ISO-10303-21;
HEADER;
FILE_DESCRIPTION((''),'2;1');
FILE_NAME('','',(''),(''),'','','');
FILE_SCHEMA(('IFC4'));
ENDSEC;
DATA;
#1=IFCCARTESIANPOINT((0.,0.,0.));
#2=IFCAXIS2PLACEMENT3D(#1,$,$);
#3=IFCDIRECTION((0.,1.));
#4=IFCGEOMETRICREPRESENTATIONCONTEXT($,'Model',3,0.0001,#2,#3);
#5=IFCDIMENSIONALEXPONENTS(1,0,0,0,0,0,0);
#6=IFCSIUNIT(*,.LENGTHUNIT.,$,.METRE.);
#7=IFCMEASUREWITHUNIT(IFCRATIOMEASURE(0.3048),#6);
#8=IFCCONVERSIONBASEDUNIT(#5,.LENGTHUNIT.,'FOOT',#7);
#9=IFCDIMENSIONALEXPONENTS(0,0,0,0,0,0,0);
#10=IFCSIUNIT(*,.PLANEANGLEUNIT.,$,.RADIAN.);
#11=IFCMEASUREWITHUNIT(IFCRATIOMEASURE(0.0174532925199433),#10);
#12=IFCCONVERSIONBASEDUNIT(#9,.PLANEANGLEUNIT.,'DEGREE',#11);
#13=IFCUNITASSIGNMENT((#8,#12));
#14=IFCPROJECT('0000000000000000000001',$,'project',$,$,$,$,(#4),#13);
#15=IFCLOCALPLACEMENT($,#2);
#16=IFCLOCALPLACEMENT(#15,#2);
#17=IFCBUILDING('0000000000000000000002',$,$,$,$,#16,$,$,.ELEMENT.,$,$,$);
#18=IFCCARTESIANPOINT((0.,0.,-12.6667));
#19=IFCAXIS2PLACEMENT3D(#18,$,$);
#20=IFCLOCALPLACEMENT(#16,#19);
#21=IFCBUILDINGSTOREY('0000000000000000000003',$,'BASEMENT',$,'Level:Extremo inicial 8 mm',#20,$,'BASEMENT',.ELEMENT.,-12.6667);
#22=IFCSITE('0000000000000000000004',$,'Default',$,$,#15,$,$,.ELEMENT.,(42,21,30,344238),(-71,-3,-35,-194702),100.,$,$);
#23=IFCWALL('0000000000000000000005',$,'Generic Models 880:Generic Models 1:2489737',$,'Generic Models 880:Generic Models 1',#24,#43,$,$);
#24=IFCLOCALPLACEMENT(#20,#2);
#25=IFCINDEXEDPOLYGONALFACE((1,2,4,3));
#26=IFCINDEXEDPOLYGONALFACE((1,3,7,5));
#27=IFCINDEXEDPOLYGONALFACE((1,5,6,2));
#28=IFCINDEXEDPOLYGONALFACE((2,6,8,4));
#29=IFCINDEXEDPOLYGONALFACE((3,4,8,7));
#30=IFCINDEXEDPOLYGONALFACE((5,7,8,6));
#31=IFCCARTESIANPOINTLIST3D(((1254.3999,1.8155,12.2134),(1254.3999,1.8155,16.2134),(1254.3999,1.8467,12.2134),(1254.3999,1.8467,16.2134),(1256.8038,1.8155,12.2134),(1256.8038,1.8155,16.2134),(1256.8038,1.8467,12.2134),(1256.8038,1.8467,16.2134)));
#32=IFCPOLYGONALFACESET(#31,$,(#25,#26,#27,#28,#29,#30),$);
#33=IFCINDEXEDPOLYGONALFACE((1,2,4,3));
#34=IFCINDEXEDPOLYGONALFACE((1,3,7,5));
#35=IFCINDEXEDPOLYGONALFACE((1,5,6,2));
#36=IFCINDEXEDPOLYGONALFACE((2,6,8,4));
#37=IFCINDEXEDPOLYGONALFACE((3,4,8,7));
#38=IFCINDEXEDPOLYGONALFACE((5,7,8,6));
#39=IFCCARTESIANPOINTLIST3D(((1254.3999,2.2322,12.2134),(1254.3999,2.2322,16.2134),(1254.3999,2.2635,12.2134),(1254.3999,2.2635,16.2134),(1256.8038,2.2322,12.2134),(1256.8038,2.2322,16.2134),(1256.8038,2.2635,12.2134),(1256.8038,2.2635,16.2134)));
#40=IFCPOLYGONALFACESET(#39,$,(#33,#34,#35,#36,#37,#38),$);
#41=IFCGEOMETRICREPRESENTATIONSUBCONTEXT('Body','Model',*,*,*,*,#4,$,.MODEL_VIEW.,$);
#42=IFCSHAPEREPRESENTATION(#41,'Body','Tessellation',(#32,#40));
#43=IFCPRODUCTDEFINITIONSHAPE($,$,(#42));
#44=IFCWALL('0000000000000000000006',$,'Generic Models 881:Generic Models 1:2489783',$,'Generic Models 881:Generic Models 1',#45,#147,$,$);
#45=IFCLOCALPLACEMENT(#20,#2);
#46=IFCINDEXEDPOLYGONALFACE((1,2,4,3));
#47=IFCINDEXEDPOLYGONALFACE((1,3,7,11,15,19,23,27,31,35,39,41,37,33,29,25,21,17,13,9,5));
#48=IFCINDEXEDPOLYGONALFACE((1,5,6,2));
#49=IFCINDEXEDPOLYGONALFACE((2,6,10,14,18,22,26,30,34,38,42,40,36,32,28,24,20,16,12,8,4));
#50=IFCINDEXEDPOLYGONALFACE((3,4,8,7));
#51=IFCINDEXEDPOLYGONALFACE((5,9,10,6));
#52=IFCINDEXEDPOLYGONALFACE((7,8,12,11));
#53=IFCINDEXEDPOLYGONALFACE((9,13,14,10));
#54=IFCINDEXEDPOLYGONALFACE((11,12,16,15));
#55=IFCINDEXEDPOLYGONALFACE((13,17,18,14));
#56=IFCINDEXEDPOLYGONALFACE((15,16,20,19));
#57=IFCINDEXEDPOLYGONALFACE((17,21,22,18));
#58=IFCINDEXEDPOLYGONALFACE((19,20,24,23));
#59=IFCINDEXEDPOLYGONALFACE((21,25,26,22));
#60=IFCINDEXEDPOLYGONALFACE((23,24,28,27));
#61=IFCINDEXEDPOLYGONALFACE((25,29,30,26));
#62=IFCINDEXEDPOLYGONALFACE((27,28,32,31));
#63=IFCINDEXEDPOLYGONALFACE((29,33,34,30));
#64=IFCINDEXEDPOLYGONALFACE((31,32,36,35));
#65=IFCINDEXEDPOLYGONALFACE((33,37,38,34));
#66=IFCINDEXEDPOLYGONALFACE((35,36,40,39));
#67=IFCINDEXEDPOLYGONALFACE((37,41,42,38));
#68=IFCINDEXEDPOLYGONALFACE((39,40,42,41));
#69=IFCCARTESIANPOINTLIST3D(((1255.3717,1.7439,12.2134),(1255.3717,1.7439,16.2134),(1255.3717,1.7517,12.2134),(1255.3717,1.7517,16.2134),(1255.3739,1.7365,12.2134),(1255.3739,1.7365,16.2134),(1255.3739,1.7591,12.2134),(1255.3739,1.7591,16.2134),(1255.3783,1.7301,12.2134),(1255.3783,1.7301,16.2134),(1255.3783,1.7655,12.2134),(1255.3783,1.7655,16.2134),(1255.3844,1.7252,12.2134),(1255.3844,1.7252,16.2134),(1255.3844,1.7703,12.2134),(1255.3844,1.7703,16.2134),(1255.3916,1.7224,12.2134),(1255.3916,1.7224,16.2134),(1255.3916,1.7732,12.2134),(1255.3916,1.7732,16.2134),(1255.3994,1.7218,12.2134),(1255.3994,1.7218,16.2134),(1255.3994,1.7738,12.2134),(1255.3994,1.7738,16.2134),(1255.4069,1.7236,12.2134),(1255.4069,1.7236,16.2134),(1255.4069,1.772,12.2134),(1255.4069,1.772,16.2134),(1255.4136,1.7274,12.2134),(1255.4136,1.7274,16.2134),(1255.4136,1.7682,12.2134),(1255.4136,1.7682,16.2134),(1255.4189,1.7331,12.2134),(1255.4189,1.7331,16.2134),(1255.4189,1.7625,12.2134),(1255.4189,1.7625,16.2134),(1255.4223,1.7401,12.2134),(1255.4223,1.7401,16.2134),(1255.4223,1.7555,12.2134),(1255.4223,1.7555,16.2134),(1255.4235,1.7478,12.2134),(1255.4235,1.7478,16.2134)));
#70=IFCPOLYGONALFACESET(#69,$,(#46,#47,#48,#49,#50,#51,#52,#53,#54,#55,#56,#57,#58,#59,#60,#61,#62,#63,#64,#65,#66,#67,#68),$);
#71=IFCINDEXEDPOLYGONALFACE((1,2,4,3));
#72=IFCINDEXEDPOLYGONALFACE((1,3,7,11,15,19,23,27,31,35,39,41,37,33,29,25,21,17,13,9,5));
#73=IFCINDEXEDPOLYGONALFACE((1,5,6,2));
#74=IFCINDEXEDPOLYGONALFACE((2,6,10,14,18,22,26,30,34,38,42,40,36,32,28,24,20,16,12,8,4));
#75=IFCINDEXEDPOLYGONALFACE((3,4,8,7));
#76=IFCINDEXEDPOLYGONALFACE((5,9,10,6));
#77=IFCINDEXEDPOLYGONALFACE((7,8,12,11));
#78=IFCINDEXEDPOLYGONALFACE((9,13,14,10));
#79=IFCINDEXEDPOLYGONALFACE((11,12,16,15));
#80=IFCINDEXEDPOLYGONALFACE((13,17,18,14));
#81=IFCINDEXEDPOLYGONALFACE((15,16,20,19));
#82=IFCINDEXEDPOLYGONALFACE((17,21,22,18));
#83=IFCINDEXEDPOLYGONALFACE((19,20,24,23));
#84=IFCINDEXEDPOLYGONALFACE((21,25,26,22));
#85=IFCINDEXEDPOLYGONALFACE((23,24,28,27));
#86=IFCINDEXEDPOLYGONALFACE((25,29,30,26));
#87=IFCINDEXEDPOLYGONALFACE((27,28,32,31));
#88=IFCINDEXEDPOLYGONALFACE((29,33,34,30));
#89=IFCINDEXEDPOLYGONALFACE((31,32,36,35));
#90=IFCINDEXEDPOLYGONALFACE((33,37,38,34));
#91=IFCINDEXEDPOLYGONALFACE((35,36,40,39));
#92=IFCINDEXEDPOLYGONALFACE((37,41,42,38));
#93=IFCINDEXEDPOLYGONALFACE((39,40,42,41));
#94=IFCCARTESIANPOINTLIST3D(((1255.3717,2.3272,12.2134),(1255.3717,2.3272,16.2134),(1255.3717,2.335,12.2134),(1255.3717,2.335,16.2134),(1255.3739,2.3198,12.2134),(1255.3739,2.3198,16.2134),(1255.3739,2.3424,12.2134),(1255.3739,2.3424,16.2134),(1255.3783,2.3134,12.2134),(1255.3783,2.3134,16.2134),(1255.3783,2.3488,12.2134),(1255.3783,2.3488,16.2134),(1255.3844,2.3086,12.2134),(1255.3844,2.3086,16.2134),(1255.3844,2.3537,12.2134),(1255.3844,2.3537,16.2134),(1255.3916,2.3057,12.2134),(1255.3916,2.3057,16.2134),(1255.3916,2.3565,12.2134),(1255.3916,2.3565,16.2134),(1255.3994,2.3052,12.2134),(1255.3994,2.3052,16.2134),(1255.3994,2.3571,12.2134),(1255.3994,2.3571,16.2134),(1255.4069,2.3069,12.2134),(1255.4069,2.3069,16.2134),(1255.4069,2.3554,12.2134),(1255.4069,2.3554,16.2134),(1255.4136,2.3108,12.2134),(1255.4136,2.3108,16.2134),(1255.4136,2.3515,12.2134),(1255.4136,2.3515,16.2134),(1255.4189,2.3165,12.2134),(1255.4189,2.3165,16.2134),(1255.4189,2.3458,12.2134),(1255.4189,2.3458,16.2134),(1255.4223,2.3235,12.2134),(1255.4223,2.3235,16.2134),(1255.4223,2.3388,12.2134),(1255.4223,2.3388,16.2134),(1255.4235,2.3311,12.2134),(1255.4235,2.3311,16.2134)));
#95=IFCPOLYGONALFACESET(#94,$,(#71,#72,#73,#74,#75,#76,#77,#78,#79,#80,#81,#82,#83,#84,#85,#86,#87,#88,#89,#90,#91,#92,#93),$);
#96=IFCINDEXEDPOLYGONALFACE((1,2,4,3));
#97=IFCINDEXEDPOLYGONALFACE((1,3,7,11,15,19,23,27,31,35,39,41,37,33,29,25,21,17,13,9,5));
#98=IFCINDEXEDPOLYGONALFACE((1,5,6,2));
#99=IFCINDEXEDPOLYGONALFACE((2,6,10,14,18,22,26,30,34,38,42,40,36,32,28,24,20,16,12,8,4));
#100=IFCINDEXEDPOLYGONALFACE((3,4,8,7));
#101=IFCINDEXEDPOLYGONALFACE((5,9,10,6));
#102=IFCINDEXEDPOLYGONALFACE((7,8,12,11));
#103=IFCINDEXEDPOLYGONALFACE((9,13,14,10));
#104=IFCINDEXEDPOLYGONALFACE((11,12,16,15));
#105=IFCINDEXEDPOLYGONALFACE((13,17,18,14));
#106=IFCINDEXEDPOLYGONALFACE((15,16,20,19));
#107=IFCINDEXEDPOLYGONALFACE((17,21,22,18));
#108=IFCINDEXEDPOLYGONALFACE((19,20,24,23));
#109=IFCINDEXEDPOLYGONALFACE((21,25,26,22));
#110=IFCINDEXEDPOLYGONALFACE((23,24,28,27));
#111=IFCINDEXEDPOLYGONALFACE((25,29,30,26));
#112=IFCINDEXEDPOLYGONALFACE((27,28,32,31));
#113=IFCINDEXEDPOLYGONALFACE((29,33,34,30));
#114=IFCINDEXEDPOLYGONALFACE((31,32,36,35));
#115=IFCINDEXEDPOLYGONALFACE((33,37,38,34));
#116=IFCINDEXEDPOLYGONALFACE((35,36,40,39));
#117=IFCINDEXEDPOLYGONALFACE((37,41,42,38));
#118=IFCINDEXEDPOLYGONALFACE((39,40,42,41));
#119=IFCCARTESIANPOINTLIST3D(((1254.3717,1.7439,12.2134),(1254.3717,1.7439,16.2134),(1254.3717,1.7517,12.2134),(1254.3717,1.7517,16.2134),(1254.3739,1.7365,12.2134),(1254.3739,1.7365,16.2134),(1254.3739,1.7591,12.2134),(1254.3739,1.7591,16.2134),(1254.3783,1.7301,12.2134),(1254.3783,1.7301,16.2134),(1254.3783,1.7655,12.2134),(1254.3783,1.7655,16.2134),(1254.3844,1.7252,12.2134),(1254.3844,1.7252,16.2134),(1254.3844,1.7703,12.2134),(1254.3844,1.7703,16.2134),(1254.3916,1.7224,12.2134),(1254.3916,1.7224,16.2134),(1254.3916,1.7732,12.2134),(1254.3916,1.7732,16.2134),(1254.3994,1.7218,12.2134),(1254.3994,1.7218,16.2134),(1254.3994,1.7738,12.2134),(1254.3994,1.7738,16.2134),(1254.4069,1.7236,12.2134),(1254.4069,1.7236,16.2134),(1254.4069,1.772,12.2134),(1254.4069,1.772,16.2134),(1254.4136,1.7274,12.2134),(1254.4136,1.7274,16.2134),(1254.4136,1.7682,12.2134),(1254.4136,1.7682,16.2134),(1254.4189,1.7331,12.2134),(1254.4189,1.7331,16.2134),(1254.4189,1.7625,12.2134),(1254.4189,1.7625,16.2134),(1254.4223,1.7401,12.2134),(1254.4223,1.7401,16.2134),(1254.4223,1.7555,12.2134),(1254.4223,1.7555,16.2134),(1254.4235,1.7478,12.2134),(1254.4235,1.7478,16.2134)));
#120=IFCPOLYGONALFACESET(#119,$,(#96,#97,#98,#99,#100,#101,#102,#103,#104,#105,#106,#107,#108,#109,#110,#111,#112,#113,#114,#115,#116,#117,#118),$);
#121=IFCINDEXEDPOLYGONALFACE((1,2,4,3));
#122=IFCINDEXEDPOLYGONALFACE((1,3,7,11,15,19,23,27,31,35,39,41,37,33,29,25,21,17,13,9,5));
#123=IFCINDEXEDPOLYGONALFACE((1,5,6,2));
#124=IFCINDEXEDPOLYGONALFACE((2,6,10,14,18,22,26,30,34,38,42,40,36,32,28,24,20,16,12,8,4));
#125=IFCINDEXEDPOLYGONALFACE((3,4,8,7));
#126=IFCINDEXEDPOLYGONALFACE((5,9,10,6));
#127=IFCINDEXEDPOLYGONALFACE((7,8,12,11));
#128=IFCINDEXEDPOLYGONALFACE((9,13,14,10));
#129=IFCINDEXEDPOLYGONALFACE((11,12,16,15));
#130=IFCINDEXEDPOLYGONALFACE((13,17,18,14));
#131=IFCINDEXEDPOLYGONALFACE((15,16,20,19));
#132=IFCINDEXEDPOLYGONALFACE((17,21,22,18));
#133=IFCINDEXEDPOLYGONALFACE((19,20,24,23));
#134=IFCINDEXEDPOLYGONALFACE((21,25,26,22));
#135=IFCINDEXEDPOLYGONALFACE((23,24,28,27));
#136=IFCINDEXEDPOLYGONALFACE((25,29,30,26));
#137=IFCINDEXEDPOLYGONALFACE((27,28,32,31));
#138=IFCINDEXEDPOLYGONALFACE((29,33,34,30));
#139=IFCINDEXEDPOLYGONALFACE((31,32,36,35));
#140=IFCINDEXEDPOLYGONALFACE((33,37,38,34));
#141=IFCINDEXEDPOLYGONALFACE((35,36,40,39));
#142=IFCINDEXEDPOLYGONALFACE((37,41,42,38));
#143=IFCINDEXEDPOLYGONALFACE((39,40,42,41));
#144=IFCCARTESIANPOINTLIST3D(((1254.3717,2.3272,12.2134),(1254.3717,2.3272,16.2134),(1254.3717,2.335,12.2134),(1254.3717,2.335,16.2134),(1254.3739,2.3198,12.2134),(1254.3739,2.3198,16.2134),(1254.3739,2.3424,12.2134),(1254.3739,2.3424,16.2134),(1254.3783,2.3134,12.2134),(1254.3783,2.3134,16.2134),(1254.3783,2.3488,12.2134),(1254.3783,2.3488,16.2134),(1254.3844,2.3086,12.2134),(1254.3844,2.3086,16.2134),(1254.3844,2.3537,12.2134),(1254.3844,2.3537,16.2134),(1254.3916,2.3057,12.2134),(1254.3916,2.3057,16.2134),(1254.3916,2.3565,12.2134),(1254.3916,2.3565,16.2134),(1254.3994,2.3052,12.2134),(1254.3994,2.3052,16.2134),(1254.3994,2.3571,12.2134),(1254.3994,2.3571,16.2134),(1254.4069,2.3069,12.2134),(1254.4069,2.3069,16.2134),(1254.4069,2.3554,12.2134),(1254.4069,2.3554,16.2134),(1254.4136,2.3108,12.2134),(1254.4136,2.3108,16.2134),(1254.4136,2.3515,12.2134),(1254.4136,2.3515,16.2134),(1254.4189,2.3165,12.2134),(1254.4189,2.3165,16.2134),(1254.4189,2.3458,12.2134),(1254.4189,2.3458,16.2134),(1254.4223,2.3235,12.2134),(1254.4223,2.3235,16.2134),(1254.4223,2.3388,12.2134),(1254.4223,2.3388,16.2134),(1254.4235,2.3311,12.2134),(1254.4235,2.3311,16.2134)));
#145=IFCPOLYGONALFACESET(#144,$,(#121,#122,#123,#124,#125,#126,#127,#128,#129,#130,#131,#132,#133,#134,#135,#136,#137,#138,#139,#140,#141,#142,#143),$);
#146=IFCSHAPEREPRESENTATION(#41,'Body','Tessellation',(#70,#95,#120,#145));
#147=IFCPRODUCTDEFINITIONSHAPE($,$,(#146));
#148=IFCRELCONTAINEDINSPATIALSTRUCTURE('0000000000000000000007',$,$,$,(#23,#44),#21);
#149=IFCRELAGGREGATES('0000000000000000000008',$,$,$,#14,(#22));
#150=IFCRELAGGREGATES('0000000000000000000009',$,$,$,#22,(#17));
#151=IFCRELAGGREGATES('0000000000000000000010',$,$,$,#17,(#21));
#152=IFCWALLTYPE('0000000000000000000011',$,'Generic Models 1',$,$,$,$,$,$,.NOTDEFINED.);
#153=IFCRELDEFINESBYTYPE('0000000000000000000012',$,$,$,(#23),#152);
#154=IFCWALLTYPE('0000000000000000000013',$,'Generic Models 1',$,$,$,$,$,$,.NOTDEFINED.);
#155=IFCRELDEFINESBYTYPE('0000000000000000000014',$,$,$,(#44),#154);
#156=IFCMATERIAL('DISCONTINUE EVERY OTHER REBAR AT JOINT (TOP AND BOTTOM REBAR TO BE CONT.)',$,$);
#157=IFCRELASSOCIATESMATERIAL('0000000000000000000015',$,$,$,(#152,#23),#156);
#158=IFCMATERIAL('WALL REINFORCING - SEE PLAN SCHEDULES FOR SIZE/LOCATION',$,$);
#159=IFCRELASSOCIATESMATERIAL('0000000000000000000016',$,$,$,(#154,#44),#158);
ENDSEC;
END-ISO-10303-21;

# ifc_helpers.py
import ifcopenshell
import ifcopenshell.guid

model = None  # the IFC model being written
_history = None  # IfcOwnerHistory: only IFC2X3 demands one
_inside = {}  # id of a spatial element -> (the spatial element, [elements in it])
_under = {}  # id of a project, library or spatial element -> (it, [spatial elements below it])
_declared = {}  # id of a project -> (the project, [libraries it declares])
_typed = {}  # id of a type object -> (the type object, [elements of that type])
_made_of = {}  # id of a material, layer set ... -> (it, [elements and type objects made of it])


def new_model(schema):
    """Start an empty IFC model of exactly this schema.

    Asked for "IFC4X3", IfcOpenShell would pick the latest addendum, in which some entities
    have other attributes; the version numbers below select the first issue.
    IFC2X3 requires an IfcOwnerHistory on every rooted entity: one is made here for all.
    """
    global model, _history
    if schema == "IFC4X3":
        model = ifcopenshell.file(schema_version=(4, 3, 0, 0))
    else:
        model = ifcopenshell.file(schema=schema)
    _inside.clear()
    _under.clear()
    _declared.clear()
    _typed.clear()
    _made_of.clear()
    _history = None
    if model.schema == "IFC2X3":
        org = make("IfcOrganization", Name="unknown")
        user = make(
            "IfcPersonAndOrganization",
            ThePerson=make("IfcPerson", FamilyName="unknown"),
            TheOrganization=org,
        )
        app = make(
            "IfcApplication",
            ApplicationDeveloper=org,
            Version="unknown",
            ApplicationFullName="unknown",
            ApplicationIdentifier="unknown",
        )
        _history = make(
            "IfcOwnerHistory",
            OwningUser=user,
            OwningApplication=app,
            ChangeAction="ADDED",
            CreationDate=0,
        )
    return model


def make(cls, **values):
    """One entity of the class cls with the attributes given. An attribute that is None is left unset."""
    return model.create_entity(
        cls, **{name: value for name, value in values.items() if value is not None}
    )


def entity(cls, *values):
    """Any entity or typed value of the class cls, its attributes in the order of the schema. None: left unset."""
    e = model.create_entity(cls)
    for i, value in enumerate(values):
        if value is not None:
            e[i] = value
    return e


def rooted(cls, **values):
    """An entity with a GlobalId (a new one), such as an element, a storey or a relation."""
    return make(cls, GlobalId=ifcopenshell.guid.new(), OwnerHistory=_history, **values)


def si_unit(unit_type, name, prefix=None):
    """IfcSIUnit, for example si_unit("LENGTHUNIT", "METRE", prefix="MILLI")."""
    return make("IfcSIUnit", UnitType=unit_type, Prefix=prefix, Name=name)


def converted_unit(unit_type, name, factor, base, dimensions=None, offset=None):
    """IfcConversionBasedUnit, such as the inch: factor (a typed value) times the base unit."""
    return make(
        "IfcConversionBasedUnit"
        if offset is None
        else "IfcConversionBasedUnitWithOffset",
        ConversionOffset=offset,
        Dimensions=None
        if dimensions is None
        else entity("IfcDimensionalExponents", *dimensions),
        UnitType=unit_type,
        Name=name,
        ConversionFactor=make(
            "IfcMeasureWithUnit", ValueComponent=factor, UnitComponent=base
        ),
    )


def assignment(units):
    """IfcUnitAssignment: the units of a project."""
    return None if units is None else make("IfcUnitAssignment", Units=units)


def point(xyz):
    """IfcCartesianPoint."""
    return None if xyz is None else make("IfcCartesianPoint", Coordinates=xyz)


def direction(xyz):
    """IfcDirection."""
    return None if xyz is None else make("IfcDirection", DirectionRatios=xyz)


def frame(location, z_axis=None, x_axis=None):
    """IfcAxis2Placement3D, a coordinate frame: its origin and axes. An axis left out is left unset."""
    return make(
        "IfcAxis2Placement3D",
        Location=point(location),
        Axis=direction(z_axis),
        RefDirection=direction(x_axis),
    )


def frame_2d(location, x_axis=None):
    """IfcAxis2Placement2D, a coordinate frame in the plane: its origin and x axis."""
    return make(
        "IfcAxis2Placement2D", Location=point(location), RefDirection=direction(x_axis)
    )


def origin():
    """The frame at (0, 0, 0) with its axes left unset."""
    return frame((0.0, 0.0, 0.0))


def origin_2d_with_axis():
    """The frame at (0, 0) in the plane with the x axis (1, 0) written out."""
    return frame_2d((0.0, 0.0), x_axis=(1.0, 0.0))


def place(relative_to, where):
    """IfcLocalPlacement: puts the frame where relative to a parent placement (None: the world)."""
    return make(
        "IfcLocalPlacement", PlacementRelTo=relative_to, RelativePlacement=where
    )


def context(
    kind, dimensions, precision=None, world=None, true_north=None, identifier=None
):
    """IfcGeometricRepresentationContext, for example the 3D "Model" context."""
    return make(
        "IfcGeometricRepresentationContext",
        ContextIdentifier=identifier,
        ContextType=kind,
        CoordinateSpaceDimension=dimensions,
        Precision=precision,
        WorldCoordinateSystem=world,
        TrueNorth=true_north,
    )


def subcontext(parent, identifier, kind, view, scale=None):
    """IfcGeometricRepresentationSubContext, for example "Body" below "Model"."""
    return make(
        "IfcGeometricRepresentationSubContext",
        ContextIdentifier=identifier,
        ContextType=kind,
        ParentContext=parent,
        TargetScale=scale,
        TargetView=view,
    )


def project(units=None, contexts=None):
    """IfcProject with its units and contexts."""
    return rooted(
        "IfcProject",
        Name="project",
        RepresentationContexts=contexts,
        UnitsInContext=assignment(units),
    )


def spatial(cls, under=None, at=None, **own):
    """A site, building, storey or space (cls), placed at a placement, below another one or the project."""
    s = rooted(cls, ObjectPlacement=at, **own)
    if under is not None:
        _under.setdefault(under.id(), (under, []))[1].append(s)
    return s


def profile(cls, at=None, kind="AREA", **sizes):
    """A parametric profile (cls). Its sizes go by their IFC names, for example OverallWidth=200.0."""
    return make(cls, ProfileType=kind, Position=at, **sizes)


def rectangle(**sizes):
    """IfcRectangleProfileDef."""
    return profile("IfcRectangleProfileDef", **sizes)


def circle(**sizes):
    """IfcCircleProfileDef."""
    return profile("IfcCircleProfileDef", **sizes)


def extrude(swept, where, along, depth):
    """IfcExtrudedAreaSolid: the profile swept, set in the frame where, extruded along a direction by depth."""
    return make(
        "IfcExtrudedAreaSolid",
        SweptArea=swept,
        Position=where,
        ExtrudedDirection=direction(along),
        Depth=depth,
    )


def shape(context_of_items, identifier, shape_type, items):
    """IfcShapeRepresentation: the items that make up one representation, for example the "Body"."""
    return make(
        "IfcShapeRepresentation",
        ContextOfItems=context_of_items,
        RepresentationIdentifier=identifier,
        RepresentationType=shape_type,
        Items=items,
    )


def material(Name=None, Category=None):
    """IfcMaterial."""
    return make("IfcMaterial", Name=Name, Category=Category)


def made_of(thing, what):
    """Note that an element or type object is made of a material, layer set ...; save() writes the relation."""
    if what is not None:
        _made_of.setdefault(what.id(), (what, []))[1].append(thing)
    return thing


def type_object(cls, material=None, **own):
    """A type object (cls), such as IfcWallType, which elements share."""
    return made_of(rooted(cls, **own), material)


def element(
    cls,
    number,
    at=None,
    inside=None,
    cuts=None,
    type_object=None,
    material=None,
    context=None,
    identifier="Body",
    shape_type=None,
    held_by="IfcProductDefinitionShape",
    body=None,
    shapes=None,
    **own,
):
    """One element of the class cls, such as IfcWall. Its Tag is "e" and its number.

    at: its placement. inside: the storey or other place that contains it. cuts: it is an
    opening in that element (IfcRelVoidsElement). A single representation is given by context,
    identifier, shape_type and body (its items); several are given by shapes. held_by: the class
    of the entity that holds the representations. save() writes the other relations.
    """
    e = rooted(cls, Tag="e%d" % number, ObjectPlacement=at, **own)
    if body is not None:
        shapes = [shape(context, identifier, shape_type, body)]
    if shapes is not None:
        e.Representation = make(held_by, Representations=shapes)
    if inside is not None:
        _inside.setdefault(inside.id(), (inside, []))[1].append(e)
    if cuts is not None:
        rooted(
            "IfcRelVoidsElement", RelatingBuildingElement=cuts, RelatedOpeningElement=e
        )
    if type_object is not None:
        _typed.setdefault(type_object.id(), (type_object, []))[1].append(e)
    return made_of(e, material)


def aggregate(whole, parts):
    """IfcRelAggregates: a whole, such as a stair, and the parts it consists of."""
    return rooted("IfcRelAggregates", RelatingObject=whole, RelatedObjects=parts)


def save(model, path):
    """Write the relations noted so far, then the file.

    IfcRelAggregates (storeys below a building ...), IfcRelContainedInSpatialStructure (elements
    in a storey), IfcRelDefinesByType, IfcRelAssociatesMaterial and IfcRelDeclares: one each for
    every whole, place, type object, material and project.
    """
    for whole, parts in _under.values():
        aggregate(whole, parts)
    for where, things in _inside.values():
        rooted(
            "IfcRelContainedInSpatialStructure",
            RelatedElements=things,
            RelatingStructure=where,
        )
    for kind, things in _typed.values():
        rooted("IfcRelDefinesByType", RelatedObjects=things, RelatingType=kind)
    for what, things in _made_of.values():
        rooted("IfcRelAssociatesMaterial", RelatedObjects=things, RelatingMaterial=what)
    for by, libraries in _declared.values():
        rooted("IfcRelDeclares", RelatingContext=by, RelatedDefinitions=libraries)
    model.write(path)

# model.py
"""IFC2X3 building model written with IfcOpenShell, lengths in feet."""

from ifc_helpers import new_model, entity, si_unit, converted_unit, direction, frame, frame_2d, origin, origin_2d_with_axis, place, context, subcontext, project, spatial, rectangle, circle, extrude, material, type_object, element, save


model = new_model("IFC2X3")

# Units and contexts
model_context = context("Model", 3, precision=0.0001, world=origin(), true_north=direction((0.0, 1.0)))
body_context = subcontext(model_context, "Body", "Model", "MODEL_VIEW")
ifc_project = project(units=[converted_unit("LENGTHUNIT", "FOOT", entity("IfcRatioMeasure", 0.3048), si_unit("LENGTHUNIT", "METRE"), dimensions=[1, 0, 0, 0, 0, 0, 0]), converted_unit("PLANEANGLEUNIT", "DEGREE", entity("IfcRatioMeasure", 0.0174532925199433), si_unit("PLANEANGLEUNIT", "RADIAN"), dimensions=[0, 0, 0, 0, 0, 0, 0])], contexts=[model_context])

# Site, building, storey
site_placement = place(None, origin())
site = spatial("IfcSite", under=ifc_project, at=site_placement, Name="Default", CompositionType="ELEMENT", RefLatitude=(42, 21, 30, 344238), RefLongitude=(-71, -3, -35, -194702), RefElevation=100.0)
building_placement = place(site_placement, origin())
building = spatial("IfcBuilding", under=site, at=building_placement, CompositionType="ELEMENT")
storey_placement = place(building_placement, frame((0.0, 0.0, -12.6667)))
storey = spatial("IfcBuildingStorey", under=building, at=storey_placement, Name="BASEMENT", ObjectType="Level:Extremo inicial 8 mm", LongName="BASEMENT", CompositionType="ELEMENT", Elevation=-12.6667)

# Walls
ifc_material_1 = material(Name="WALL REINFORCING - SEE PLAN SCHEDULES FOR SIZE/LOCATION")
ifc_material_2 = material(Name="DISCONTINUE EVERY OTHER REBAR AT JOINT (TOP AND BOTTOM REBAR TO BE CONT.)")
wall_type_1 = type_object("IfcWallType", Name="Generic Models 1", PredefinedType="NOTDEFINED", material=ifc_material_2)
wall_1_placement = place(storey_placement, frame((1254.3999, 1.8155, 12.2134)))
element("IfcWall", 1, at=wall_1_placement, inside=storey, type_object=wall_type_1, material=ifc_material_2, Name="Generic Models 880:Generic Models 1:2489737", ObjectType="Generic Models 880:Generic Models 1", context=body_context, shape_type="SweptSolid", body=[
    extrude(rectangle(XDim=2.4038, YDim=0.0312, at=frame_2d((0.0, 0.0), x_axis=(1.0, 0.0))), frame((1.2019, 0.0156, 0.0), z_axis=(0.0, 0.0, 1.0), x_axis=(-1.0, 0.0, 0.0)), (0.0, 0.0, 1.0), 4.0),
    extrude(rectangle(XDim=0.0312, YDim=2.4038, at=frame_2d((0.0, 0.0), x_axis=(1.0, 0.0))), frame((1.2019, 0.4324, 0.0), z_axis=(0.0, 0.0, 1.0), x_axis=(0.0, 1.0, 0.0)), (0.0, 0.0, 1.0), 4.0),
])
wall_type_2 = type_object("IfcWallType", Name="Generic Models 1", PredefinedType="NOTDEFINED", material=ifc_material_1)
wall_2_placement = place(storey_placement, frame((1254.3714, 1.7218, 12.2134)))
element("IfcWall", 2, at=wall_2_placement, inside=storey, type_object=wall_type_2, material=ifc_material_1, Name="Generic Models 881:Generic Models 1:2489783", ObjectType="Generic Models 881:Generic Models 1", context=body_context, shape_type="SweptSolid", body=[
    extrude(circle(Radius=0.026, at=origin_2d_with_axis()), frame((1.026, 0.026, 0.0)), (0.0, 0.0, 1.0), 4.0),
    extrude(circle(Radius=0.026, at=origin_2d_with_axis()), frame((1.026, 0.6094, 0.0)), (0.0, 0.0, 1.0), 4.0),
    extrude(circle(Radius=0.026, at=origin_2d_with_axis()), frame((0.026, 0.026, 0.0)), (0.0, 0.0, 1.0), 4.0),
    extrude(circle(Radius=0.026, at=origin_2d_with_axis()), frame((0.026, 0.6094, 0.0)), (0.0, 0.0, 1.0), 4.0),
])

save(model, "model.ifc")
